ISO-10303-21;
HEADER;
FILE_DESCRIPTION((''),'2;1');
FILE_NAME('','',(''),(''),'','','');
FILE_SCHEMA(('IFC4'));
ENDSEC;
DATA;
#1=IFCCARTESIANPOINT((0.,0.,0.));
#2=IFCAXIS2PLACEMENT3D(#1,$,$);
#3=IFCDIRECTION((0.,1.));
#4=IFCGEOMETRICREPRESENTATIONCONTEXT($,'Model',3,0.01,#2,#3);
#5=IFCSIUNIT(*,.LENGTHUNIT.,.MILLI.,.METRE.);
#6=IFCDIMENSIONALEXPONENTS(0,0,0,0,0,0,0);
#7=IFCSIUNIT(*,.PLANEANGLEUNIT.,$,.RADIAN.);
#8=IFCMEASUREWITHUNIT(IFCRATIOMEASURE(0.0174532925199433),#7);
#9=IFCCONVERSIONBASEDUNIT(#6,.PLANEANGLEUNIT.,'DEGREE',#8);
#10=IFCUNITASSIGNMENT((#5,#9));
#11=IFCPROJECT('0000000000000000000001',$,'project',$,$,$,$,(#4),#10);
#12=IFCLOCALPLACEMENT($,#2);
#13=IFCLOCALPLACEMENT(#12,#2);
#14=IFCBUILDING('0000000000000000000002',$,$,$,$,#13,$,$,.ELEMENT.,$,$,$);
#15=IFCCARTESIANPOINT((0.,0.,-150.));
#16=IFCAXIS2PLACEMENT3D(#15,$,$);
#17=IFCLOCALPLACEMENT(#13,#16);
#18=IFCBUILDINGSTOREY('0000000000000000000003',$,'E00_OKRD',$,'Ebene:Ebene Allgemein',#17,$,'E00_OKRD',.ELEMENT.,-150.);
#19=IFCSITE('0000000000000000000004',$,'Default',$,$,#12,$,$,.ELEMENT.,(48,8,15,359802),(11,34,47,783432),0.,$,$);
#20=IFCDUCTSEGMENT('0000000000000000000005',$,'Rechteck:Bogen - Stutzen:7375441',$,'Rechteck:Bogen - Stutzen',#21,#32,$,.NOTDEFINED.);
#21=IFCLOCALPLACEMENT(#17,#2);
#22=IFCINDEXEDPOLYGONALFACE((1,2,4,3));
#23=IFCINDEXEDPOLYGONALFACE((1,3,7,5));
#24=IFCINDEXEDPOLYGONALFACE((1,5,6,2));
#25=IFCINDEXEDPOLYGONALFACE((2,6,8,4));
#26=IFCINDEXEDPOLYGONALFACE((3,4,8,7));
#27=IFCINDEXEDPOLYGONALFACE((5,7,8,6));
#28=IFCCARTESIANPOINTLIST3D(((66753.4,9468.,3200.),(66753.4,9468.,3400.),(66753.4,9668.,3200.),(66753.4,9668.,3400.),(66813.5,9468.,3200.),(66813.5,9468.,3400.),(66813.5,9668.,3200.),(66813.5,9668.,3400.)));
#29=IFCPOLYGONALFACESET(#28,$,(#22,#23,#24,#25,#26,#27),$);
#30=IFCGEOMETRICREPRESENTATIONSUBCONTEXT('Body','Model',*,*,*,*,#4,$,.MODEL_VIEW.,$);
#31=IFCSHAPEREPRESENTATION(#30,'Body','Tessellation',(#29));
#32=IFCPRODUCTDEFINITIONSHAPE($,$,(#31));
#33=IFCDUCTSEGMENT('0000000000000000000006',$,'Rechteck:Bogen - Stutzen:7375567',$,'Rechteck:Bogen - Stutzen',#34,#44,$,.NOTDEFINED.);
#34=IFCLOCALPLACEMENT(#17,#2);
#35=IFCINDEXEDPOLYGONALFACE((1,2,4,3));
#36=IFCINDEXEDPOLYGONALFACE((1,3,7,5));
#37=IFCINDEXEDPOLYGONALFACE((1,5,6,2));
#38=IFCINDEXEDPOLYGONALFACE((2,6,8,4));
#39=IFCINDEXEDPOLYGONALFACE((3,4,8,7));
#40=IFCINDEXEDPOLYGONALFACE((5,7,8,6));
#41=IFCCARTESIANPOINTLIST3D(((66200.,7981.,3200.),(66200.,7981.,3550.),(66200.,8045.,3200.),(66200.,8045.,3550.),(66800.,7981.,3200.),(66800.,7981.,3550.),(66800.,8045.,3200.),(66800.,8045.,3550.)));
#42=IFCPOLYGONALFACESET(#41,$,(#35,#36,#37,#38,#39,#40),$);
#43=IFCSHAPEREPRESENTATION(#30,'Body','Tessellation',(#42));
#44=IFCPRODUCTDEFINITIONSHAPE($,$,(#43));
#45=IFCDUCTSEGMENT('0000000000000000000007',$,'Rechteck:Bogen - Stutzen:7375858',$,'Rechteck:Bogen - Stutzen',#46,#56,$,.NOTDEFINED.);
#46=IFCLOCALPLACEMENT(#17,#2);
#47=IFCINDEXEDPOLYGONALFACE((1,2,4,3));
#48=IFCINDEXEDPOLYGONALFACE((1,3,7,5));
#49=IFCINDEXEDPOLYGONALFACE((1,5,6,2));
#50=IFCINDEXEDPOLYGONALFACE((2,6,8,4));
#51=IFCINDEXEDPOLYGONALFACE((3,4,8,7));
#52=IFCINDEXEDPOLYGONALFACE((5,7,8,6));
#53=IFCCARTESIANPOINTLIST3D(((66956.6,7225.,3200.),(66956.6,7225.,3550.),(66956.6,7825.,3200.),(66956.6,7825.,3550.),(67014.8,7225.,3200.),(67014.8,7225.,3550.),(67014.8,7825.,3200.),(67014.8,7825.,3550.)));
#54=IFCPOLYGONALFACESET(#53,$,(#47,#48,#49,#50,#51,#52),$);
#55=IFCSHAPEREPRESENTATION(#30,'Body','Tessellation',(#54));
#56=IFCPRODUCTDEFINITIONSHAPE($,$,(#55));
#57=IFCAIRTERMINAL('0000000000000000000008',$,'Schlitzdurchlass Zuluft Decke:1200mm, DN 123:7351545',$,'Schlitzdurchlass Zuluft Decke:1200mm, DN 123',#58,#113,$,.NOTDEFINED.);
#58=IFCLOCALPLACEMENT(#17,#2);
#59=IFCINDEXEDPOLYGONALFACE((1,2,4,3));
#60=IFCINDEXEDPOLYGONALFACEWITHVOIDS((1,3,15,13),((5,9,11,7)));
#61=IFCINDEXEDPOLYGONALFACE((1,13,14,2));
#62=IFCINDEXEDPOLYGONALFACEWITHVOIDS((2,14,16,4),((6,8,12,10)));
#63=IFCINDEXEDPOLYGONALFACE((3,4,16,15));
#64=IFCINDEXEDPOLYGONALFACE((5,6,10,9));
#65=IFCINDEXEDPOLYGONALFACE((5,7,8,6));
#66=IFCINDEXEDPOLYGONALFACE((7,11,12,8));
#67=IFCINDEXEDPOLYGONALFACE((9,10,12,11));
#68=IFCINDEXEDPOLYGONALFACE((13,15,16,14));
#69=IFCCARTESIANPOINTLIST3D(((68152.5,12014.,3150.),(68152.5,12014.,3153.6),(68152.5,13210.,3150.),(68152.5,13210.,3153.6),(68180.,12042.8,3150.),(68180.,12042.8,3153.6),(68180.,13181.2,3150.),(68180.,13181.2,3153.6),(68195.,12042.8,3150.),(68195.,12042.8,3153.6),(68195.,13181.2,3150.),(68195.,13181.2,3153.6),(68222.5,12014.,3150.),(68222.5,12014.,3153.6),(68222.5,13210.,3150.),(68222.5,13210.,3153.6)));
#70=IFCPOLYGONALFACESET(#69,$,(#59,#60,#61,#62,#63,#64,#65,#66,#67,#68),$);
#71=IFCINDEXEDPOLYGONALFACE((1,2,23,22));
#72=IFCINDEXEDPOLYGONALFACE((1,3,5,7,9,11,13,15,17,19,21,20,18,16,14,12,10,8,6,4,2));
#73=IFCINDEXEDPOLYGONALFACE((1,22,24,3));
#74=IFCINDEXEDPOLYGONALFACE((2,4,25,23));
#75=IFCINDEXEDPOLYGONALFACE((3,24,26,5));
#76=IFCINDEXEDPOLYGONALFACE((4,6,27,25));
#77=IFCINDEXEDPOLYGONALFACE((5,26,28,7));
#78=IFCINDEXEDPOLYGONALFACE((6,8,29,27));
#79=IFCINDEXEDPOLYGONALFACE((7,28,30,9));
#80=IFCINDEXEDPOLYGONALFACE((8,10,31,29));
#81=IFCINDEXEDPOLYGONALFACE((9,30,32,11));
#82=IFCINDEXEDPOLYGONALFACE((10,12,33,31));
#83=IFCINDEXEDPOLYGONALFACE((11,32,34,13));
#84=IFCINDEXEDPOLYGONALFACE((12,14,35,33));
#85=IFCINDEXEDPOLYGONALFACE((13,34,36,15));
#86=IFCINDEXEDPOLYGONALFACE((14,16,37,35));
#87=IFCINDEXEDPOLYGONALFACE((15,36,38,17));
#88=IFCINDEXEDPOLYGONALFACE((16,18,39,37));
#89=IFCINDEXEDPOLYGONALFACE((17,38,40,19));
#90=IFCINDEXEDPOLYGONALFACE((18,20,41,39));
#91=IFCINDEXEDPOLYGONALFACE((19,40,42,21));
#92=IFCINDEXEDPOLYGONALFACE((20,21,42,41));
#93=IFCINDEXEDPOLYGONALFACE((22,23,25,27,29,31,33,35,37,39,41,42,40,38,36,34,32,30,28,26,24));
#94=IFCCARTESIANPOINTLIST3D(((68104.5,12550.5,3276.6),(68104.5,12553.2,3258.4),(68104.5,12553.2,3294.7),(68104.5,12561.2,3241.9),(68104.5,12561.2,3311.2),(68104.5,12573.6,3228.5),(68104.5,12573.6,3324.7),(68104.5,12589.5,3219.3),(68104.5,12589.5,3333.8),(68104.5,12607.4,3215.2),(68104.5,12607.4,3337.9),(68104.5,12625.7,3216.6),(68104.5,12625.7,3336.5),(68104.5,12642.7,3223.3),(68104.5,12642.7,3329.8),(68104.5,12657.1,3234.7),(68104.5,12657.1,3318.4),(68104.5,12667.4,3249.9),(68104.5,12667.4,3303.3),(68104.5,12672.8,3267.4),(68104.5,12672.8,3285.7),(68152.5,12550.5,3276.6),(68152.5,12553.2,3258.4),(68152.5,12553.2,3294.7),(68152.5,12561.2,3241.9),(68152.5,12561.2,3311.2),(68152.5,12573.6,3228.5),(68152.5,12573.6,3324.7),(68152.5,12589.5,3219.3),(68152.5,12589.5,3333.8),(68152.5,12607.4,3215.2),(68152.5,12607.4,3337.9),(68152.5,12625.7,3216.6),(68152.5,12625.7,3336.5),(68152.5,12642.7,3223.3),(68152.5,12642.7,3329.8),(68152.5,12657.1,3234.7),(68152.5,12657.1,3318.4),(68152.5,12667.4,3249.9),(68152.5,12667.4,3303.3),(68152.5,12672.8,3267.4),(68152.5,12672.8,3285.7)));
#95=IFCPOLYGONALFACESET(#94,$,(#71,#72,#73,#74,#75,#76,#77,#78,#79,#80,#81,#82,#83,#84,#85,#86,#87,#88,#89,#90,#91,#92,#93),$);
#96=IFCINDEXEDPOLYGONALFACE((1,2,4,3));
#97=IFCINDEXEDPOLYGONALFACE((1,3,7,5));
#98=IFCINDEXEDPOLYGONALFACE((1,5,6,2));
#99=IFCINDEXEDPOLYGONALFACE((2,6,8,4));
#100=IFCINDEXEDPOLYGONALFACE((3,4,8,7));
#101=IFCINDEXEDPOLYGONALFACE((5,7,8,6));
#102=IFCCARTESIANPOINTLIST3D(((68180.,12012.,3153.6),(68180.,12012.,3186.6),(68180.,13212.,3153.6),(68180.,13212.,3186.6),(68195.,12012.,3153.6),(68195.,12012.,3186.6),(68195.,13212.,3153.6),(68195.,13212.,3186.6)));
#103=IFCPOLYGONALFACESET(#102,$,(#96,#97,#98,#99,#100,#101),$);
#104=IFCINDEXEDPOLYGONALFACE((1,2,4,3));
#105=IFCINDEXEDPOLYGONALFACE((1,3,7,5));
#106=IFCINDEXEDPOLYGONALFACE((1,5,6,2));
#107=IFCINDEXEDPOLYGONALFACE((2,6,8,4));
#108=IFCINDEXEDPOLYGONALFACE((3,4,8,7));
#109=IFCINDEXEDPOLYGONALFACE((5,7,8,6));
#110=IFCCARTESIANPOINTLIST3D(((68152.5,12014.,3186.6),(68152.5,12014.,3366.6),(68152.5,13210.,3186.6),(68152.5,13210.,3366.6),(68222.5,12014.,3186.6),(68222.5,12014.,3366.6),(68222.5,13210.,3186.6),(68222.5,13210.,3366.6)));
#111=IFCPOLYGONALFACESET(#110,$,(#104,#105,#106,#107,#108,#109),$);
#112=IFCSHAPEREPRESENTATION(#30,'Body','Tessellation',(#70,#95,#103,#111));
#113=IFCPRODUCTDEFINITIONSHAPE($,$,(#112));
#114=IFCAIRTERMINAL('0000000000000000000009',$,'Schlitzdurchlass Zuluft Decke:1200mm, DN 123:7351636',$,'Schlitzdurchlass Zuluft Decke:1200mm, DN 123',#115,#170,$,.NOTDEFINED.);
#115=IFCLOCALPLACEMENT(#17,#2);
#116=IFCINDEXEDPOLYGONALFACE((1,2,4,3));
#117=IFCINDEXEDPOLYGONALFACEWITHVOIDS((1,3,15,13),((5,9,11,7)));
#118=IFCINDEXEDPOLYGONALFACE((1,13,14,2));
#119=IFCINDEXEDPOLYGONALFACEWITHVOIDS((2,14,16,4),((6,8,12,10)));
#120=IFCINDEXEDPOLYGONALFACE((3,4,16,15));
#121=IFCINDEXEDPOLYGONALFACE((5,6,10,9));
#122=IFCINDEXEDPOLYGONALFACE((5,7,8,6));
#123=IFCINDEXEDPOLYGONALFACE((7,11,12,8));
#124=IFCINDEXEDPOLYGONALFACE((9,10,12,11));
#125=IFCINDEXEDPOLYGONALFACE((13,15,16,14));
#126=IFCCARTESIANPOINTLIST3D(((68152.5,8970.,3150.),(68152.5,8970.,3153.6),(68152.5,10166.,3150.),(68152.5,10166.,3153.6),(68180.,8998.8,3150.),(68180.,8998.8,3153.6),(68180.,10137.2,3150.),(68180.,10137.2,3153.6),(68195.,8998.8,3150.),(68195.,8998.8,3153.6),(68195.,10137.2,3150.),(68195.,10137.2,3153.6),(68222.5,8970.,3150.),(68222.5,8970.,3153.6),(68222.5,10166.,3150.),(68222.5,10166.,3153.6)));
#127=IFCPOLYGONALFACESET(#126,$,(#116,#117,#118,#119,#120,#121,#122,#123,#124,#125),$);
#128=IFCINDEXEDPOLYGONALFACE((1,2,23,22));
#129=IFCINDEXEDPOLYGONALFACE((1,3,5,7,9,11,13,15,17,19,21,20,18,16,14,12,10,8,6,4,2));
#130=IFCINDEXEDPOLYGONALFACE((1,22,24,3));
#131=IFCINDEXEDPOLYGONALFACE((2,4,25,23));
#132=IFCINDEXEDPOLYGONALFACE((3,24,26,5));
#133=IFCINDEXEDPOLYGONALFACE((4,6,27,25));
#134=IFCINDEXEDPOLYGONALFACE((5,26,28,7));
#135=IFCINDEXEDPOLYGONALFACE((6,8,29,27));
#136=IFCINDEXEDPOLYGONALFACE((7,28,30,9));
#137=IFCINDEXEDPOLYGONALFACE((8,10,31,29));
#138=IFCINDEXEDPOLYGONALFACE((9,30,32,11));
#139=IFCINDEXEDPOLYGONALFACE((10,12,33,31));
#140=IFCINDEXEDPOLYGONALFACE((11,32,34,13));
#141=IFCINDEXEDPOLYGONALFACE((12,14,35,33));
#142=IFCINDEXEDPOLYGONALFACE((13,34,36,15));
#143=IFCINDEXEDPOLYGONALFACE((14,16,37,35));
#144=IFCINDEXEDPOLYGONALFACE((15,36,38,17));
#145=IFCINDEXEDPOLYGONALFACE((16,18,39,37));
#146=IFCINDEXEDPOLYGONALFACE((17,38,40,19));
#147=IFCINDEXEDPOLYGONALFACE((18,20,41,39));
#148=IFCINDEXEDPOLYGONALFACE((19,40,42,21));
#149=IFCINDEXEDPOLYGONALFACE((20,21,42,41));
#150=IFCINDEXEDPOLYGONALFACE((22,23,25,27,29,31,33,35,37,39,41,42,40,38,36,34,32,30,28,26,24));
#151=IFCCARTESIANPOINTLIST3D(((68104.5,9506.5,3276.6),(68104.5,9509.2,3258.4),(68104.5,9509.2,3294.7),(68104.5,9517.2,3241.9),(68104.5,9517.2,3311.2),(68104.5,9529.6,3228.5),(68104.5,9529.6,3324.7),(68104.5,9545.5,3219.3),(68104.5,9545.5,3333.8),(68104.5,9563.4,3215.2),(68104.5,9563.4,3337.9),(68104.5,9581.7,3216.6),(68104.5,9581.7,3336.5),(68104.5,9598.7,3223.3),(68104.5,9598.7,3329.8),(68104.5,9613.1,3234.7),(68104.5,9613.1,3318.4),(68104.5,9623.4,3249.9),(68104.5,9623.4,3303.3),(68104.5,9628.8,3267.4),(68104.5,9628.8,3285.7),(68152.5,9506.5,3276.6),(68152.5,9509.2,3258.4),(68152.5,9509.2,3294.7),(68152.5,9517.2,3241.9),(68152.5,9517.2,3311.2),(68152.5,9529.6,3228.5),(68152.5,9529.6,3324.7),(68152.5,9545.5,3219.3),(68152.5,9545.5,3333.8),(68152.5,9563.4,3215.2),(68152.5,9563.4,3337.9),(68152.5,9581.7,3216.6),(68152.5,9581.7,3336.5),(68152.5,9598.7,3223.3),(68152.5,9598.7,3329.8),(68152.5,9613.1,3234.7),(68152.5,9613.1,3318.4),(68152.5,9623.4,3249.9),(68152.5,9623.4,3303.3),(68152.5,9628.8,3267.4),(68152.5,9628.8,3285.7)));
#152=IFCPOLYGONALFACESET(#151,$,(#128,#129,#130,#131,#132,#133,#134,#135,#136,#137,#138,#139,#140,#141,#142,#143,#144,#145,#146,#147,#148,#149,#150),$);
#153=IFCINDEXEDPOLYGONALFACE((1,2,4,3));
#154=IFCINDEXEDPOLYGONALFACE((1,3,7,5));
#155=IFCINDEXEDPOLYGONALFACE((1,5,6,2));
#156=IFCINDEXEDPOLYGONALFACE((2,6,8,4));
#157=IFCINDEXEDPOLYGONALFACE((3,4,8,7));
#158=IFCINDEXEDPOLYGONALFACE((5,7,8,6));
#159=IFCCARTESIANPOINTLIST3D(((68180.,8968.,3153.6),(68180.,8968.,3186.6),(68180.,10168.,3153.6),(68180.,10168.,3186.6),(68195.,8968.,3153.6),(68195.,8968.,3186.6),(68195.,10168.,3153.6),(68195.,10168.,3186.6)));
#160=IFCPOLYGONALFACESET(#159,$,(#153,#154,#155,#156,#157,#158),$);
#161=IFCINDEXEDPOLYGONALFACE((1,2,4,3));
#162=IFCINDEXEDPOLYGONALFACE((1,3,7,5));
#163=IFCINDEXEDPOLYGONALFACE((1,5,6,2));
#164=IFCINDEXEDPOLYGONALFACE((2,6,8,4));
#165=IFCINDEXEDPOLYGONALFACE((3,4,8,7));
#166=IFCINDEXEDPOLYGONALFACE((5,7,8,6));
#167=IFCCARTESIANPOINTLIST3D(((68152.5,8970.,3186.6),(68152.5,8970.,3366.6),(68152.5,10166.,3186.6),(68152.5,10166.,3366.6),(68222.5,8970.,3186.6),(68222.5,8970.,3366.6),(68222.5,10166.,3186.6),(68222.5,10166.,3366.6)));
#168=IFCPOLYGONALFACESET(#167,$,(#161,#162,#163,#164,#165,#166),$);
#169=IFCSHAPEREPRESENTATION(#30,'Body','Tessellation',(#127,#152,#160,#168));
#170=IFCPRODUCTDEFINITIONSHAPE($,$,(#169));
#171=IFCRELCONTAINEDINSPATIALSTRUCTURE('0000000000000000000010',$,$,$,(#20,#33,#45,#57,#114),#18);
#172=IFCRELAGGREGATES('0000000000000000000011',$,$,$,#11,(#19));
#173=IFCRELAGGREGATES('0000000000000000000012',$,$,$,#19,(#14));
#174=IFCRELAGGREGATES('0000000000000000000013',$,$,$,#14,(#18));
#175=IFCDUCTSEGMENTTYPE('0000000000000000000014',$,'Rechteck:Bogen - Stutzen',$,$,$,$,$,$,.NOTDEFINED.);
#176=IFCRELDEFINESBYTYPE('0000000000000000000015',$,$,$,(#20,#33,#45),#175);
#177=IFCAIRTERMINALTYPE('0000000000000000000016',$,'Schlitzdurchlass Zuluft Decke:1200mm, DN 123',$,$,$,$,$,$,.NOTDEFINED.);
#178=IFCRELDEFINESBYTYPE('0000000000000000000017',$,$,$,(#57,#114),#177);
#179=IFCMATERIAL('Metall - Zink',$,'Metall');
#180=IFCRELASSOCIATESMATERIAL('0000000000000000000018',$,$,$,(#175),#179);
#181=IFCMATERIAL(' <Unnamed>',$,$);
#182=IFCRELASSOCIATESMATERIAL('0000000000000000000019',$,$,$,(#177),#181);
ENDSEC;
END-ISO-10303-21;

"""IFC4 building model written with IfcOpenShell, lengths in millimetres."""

from ifc_helpers import new_model, entity, si_unit, converted_unit, direction, frame, frame_2d, origin, origin_2d_with_axis, place, context, subcontext, project, spatial, polyline, rectangle, circle, outline, extrude, source, transform, mapped, material, type_object, type_shapes, element, save


model = new_model("IFC4")

# Units and contexts
model_context = context("Model", 3, precision=0.01, world=origin(), true_north=direction((0.0, 1.0)))
body_context = subcontext(model_context, "Body", "Model", "MODEL_VIEW")
ifc_project = project(units=[si_unit("LENGTHUNIT", "METRE", prefix="MILLI"), converted_unit("PLANEANGLEUNIT", "DEGREE", entity("IfcRatioMeasure", 0.0174532925199433), si_unit("PLANEANGLEUNIT", "RADIAN"), dimensions=[0, 0, 0, 0, 0, 0, 0])], contexts=[model_context])

# Site, building, storey
site_placement = place(None, origin())
site = spatial("IfcSite", under=ifc_project, at=site_placement, Name="Default", CompositionType="ELEMENT", RefLatitude=(48, 8, 15, 359802), RefLongitude=(11, 34, 47, 783432), RefElevation=0.0)
building_placement = place(site_placement, origin())
building = spatial("IfcBuilding", under=site, at=building_placement, CompositionType="ELEMENT")
storey_placement = place(building_placement, frame((0.0, 0.0, -150.0)))
storey = spatial("IfcBuildingStorey", under=building, at=storey_placement, Name="E00_OKRD", ObjectType="Ebene:Ebene Allgemein", LongName="E00_OKRD", CompositionType="ELEMENT", Elevation=-150.0)

# Duct segments
ifc_material_1 = material(Name="Metall - Zink", Category="Metall")
duct_segment_type_1 = type_object("IfcDuctSegmentType", Name="Rechteck:Bogen - Stutzen", PredefinedType="NOTDEFINED", material=ifc_material_1)
duct_segment_1_placement = place(storey_placement, frame((66753.4, 9468.0, 3200.0)))
element("IfcDuctSegment", 1, at=duct_segment_1_placement, inside=storey, type_object=duct_segment_type_1, Name="Rechteck:Bogen - Stutzen:7375441", ObjectType="Rechteck:Bogen - Stutzen", PredefinedType="NOTDEFINED", context=body_context, shape_type="SweptSolid", body=[
    extrude(rectangle(XDim=60.1, YDim=200.0, at=frame_2d((0.0, 0.0), x_axis=(1.0, 0.0))), frame((30.0, 100.0, 0.0)), (0.0, 0.0, 1.0), 200.0),
])
duct_segment_2_placement = place(storey_placement, frame((66200.0, 7981.0, 3200.0)))
element("IfcDuctSegment", 2, at=duct_segment_2_placement, inside=storey, type_object=duct_segment_type_1, Name="Rechteck:Bogen - Stutzen:7375567", ObjectType="Rechteck:Bogen - Stutzen", PredefinedType="NOTDEFINED", context=body_context, shape_type="SweptSolid", body=[
    extrude(rectangle(XDim=64.0, YDim=600.0, at=frame_2d((0.0, 0.0), x_axis=(1.0, 0.0))), frame((300.0, 32.0, 0.0), z_axis=(0.0, 0.0, 1.0), x_axis=(0.0, 1.0, 0.0)), (0.0, 0.0, 1.0), 350.0),
])
duct_segment_3_placement = place(storey_placement, frame((66956.6, 7225.0, 3200.0)))
element("IfcDuctSegment", 3, at=duct_segment_3_placement, inside=storey, type_object=duct_segment_type_1, Name="Rechteck:Bogen - Stutzen:7375858", ObjectType="Rechteck:Bogen - Stutzen", PredefinedType="NOTDEFINED", context=body_context, shape_type="SweptSolid", body=[
    extrude(rectangle(XDim=58.3, YDim=600.0, at=frame_2d((0.0, 0.0), x_axis=(1.0, 0.0))), frame((29.1, 300.0, 0.0), z_axis=(0.0, 0.0, 1.0), x_axis=(-1.0, 0.0, 0.0)), (0.0, 0.0, 1.0), 350.0),
])

# Air terminals
ifc_material_2 = material(Name=" <Unnamed>")
air_terminal_type = type_object("IfcAirTerminalType", Name="Schlitzdurchlass Zuluft Decke:1200mm, DN 123", PredefinedType="NOTDEFINED", material=ifc_material_2)
shared_shape_1 = source(origin(), body_context, "Body", "SweptSolid", [
    extrude(outline(polyline([(-598.0, -35.0), (598.0, -35.0), (598.0, 35.0), (-598.0, 35.0), (-598.0, -35.0)]), holes=[polyline([(-569.2, -7.5), (-569.2, 7.5), (569.2, 7.5), (569.2, -7.5), (-569.2, -7.5)])]), frame((600.0, 35.0, 0.0), z_axis=(0.0, 0.0, 1.0), x_axis=(-1.0, 0.0, 0.0)), (0.0, 0.0, 1.0), 3.6),
    extrude(circle(Radius=61.5, at=frame_2d((0.0, 0.0), x_axis=(1.0, 0.0))), frame((600.0, 70.0, 126.6), z_axis=(0.0, 1.0, 0.0), x_axis=(-1.0, 0.0, 0.0)), (0.0, 0.0, 1.0), 48.0),
    extrude(rectangle(XDim=1200.0, YDim=15.0, at=origin_2d_with_axis()), frame((600.0, 35.0, 3.6), z_axis=(0.0, 0.0, 1.0), x_axis=(-1.0, 0.0, 0.0)), (0.0, 0.0, 1.0), 33.0),
    extrude(rectangle(XDim=1196.0, YDim=70.0, at=origin_2d_with_axis()), frame((600.0, 35.0, 36.6), z_axis=(0.0, 0.0, 1.0), x_axis=(-1.0, 0.0, 0.0)), (0.0, 0.0, 1.0), 180.0),
])
type_shapes(air_terminal_type, [shared_shape_1])
for number, where, z_axis, x_axis, name in (
    (4, (68222.5, 12012.0, 3150.0), (0.0, 0.0, 1.0), (0.0, 1.0, 0.0), "Schlitzdurchlass Zuluft Decke:1200mm, DN 123:7351545"),
    (5, (68222.5, 8968.0, 3150.0), (0.0, 0.0, 1.0), (0.0, 1.0, 0.0), "Schlitzdurchlass Zuluft Decke:1200mm, DN 123:7351636"),
):
    element("IfcAirTerminal", number, at=place(storey_placement, frame(where, z_axis=z_axis, x_axis=x_axis)), inside=storey, type_object=air_terminal_type, Name=name, ObjectType="Schlitzdurchlass Zuluft Decke:1200mm, DN 123", PredefinedType="NOTDEFINED", context=body_context, shape_type="MappedRepresentation", body=[
        mapped(shared_shape_1, transform((0.0, 0.0, 0.0), scale=1.0)),
    ])

save(model, "model.ifc")
